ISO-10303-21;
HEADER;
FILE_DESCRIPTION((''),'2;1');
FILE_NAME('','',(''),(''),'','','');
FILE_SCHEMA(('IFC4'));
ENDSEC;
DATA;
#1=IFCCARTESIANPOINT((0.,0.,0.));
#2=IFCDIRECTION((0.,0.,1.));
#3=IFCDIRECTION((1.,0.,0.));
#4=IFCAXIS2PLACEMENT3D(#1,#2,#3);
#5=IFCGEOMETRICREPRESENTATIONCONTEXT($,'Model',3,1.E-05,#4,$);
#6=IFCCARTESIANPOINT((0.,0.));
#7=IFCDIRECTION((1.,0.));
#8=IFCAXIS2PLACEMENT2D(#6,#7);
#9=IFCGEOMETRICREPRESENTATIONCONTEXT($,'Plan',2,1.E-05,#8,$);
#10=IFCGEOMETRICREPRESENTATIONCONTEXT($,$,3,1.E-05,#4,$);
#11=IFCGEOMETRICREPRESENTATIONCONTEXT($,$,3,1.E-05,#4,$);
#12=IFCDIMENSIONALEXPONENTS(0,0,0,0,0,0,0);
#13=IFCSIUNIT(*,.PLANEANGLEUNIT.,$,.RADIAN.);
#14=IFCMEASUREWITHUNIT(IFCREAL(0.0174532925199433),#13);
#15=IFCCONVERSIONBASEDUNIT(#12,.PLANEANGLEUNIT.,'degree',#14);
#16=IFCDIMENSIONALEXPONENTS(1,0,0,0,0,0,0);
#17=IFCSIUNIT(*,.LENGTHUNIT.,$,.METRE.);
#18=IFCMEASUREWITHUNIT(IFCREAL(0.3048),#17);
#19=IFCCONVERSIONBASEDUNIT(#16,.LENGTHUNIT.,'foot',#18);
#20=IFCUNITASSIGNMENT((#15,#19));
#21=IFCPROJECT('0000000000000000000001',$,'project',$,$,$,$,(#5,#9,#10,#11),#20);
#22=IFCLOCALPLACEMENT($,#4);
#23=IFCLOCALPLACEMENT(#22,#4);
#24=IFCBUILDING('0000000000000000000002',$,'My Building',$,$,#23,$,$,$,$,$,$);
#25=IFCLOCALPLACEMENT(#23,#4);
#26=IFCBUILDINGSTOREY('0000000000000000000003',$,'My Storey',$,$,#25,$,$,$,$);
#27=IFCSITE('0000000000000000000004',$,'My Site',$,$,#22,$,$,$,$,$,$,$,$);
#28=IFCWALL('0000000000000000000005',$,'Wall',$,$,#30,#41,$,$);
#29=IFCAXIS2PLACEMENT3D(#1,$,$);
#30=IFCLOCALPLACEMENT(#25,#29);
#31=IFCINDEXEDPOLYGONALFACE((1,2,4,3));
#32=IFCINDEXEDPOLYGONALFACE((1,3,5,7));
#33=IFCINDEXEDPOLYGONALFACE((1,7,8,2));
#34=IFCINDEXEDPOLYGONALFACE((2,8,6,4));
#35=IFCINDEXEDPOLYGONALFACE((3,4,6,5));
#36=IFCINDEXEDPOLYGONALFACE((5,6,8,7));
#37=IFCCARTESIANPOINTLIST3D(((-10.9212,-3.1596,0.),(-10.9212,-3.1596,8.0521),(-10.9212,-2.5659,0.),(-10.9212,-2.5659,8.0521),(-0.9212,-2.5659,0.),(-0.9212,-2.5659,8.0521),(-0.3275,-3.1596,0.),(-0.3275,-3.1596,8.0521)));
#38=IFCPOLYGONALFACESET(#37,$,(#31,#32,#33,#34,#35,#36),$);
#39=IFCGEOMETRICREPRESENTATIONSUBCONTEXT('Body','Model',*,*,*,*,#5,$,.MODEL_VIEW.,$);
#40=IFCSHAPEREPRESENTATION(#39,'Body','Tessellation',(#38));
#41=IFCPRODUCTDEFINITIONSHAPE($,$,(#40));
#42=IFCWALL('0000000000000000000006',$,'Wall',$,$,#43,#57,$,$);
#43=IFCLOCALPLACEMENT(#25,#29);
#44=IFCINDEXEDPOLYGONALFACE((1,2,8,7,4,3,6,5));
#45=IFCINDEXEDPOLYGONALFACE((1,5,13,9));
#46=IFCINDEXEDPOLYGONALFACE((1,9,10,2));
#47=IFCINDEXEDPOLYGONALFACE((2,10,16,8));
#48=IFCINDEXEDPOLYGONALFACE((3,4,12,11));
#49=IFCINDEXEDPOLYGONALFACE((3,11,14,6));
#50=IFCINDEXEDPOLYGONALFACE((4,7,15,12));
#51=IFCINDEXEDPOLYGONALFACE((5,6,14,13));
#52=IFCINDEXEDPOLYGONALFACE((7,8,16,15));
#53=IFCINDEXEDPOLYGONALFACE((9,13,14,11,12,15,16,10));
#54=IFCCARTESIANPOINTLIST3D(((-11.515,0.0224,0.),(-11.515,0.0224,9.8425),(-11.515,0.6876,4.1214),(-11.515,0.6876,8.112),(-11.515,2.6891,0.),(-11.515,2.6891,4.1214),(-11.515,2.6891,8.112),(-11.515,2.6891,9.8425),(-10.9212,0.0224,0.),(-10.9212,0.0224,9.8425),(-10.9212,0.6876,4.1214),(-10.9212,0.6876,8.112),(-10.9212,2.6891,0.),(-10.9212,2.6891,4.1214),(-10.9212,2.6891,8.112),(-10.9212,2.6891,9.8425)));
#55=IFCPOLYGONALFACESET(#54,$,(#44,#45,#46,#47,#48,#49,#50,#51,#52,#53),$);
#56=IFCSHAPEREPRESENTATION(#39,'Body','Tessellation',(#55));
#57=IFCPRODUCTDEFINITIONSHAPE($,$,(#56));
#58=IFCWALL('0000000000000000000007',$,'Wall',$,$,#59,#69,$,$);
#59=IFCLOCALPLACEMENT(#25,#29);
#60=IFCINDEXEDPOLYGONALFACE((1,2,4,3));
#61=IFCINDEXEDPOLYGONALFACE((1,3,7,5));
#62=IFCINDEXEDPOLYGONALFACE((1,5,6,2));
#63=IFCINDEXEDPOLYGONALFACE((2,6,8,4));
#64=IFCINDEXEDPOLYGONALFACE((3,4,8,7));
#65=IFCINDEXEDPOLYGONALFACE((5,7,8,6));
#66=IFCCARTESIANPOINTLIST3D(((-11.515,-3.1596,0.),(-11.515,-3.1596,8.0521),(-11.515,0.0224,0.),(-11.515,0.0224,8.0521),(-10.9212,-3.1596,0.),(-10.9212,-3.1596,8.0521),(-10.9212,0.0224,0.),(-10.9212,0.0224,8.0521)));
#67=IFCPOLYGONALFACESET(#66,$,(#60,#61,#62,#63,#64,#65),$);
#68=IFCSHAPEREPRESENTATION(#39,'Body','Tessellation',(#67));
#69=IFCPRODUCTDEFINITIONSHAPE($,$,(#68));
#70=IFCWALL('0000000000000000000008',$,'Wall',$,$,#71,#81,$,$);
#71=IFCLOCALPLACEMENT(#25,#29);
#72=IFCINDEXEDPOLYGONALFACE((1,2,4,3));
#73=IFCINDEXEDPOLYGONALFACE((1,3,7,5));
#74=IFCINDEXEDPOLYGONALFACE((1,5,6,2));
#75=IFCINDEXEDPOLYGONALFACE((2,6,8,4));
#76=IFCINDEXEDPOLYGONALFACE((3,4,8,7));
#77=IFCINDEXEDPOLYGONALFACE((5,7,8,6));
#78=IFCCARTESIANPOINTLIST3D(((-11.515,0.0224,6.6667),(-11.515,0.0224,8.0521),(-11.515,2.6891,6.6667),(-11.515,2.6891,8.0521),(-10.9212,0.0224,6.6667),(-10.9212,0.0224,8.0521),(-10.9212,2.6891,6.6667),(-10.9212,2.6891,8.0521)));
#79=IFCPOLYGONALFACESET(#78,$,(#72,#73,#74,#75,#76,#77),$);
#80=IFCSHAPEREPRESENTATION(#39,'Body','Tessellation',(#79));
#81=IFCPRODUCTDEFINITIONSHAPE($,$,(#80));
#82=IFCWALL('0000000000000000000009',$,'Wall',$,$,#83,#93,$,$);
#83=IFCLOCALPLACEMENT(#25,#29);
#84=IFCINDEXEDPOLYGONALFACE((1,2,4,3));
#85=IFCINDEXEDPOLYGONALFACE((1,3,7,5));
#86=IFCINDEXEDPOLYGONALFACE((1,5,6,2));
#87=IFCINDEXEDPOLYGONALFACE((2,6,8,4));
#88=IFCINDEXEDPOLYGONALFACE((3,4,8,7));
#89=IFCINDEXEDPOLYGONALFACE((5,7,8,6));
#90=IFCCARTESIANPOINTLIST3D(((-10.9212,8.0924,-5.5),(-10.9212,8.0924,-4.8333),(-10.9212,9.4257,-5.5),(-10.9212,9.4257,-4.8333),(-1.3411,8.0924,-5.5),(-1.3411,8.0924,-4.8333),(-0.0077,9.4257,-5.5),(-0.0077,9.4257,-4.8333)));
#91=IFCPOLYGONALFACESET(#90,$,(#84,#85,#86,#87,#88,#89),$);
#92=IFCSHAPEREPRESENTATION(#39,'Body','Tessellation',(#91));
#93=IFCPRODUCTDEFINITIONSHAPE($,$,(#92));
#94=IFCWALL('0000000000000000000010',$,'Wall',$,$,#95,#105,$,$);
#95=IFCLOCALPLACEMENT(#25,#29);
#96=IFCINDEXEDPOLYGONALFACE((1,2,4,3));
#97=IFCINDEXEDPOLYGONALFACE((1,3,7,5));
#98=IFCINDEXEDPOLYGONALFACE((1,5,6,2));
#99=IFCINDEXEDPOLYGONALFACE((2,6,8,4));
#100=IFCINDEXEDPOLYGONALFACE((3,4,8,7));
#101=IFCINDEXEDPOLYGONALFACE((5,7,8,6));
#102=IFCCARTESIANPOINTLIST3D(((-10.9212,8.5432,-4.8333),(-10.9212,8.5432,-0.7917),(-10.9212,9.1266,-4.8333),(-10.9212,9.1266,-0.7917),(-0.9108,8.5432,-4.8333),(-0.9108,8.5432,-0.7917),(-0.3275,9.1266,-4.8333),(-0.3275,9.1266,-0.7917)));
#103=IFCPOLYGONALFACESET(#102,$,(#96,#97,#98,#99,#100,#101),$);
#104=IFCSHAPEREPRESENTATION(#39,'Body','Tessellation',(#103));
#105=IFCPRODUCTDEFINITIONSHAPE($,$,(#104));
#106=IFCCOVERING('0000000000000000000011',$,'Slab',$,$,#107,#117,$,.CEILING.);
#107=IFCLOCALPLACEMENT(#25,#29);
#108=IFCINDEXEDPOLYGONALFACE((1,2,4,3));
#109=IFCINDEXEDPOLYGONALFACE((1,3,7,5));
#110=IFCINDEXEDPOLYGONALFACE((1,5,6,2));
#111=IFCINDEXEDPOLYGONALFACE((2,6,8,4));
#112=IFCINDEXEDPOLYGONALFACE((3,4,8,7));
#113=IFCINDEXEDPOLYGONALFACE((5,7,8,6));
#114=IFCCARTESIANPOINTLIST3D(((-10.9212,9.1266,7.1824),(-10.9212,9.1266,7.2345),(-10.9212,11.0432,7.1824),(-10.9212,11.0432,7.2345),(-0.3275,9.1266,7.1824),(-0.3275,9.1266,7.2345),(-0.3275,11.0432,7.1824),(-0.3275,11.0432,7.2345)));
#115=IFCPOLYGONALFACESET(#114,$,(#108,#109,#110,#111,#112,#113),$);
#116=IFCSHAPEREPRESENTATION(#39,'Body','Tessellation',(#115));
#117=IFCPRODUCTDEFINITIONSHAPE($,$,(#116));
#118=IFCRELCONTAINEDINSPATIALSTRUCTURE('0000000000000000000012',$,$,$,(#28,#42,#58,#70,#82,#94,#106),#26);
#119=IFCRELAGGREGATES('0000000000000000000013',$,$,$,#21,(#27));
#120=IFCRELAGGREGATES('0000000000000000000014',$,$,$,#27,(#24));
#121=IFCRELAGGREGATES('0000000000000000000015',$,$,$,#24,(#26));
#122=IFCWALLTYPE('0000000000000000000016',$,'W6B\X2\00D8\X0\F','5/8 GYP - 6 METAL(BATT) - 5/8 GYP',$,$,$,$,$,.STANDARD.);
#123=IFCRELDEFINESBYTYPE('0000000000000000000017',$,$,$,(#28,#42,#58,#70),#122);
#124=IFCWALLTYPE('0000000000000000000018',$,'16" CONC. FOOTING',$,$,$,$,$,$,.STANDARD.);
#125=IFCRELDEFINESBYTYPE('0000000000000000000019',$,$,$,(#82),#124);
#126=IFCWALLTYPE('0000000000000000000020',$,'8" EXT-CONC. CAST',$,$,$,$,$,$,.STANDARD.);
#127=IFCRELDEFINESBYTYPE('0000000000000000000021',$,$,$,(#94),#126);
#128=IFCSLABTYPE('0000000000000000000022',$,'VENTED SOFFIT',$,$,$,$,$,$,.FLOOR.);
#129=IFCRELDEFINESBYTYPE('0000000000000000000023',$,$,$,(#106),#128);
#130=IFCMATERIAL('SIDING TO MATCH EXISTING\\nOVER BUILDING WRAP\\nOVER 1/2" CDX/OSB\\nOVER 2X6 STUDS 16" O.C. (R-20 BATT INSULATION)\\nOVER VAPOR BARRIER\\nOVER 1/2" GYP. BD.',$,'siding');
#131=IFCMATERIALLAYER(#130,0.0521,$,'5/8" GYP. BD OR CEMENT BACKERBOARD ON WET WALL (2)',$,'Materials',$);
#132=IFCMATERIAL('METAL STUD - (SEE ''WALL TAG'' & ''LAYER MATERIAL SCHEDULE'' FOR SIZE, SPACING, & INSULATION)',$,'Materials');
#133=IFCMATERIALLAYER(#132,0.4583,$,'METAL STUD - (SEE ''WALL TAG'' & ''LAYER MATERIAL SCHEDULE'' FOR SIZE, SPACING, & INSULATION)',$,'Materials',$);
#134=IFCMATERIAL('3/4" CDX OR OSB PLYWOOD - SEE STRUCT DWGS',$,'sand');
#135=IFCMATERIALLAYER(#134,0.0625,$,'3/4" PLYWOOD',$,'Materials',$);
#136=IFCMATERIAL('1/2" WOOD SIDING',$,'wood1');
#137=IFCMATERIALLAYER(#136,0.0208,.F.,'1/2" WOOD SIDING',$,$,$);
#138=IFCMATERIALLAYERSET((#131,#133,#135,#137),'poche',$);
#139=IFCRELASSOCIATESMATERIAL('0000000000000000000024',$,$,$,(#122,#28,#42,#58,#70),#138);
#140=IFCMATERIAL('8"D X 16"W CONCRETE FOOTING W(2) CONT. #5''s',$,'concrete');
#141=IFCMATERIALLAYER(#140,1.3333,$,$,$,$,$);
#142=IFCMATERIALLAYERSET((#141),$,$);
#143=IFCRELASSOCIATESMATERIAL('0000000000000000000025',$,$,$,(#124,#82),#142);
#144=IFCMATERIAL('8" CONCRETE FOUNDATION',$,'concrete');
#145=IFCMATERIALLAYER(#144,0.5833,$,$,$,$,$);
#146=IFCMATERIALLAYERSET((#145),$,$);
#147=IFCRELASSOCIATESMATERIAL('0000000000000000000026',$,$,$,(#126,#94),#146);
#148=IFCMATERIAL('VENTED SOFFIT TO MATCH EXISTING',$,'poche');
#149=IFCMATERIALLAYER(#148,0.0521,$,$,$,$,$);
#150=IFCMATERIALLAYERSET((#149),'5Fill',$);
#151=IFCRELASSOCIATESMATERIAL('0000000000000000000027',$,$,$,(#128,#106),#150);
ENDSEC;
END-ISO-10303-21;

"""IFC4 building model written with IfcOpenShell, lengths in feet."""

from ifc_helpers import new_model, entity, si_unit, converted_unit, frame, origin_with_axes, origin_2d_with_axis, place, context, subcontext, project, spatial, line, indexed_curve, outline, extrude, clip, halfspace, source, transform, mapped, material, layer, layer_set, layer_usage, type_object, element, save


model = new_model("IFC4")

# Units and contexts
model_context = context("Model", 3, precision=1e-05, world=origin_with_axes())
plan_context = context("Plan", 2, precision=1e-05, world=origin_2d_with_axis())
context_of_model_1 = context(None, 3, precision=1e-05, world=origin_with_axes())
context_of_model_2 = context(None, 3, precision=1e-05, world=origin_with_axes())
body_context = subcontext(model_context, "Body", "Model", "MODEL_VIEW")
ifc_project = project(units=[converted_unit("PLANEANGLEUNIT", "degree", entity("IfcReal", 0.0174532925199433), si_unit("PLANEANGLEUNIT", "RADIAN"), dimensions=[0, 0, 0, 0, 0, 0, 0]), converted_unit("LENGTHUNIT", "foot", entity("IfcReal", 0.3048), si_unit("LENGTHUNIT", "METRE"), dimensions=[1, 0, 0, 0, 0, 0, 0])], contexts=[model_context, plan_context, context_of_model_1, context_of_model_2])

# Site, building, storey
site_placement = place(None, origin_with_axes())
site = spatial("IfcSite", under=ifc_project, at=site_placement, Name="My Site")
building_placement = place(site_placement, origin_with_axes())
building = spatial("IfcBuilding", under=site, at=building_placement, Name="My Building")
storey_placement = place(building_placement, origin_with_axes())
storey = spatial("IfcBuildingStorey", under=building, at=storey_placement, Name="My Storey")

# Shared definitions
ifc_material_1 = material(Name="SIDING TO MATCH EXISTING\\nOVER BUILDING WRAP\\nOVER 1/2\" CDX/OSB\\nOVER 2X6 STUDS 16\" O.C. (R-20 BATT INSULATION)\\nOVER VAPOR BARRIER\\nOVER 1/2\" GYP. BD.", Category="siding")
ifc_layer_1 = layer(ifc_material_1, 0.0521, Name="5/8\" GYP. BD OR CEMENT BACKERBOARD ON WET WALL (2)", Category="Materials")
ifc_material_2 = material(Name="METAL STUD - (SEE 'WALL TAG' & 'LAYER MATERIAL SCHEDULE' FOR SIZE, SPACING, & INSULATION)", Category="Materials")
ifc_layer_2 = layer(ifc_material_2, 0.4583, Name="METAL STUD - (SEE 'WALL TAG' & 'LAYER MATERIAL SCHEDULE' FOR SIZE, SPACING, & INSULATION)", Category="Materials")
ifc_material_3 = material(Name="3/4\" CDX OR OSB PLYWOOD - SEE STRUCT DWGS", Category="sand")
ifc_layer_3 = layer(ifc_material_3, 0.0625, Name="3/4\" PLYWOOD", Category="Materials")
ifc_material_4 = material(Name="1/2\" WOOD SIDING", Category="wood1")
ifc_layer_4 = layer(ifc_material_4, 0.0208, ventilated=False, Name="1/2\" WOOD SIDING")
ifc_layer_set_1 = layer_set([ifc_layer_1, ifc_layer_2, ifc_layer_3, ifc_layer_4], Name="poche")
wall_type_1 = type_object("IfcWallType", Name="W6BØF", Description="5/8 GYP - 6 METAL(BATT) - 5/8 GYP", PredefinedType="STANDARD", material=ifc_layer_set_1)

# Wall
ifc_layer_usage_1 = layer_usage(ifc_layer_set_1, "AXIS2", "POSITIVE", 0.0)
wall_1_placement = place(storey_placement, frame((-0.3275, -2.5659, 0.0), z_axis=(0.0, 0.0, 1.0), x_axis=(-1.0, 0.0, 0.0)))
element("IfcWall", 1, at=wall_1_placement, inside=storey, type_object=wall_type_1, material=ifc_layer_usage_1, Name="Wall", context=body_context, shape_type="Clipping", body=[
    clip(extrude(outline(indexed_curve([(0.0, 0.0), (0.0, 0.5937), (10.5938, 0.5937), (10.5938, 0.0), (0.0, 0.0)], self_intersect=False)), origin_with_axes(), (0.0, 0.0, 1.0), 8.0521), halfspace(frame((0.5937, 0.0, 0.0), z_axis=(-0.707107, -0.707107, 0.0), x_axis=(-0.707107, 0.707107, 0.0)), False)),
])

# Wall, opening
ifc_layer_usage_2 = layer_usage(ifc_layer_set_1, "AXIS2", "POSITIVE", 0.0)
wall_2_placement = place(storey_placement, frame((-11.515, 2.6891, 0.0), z_axis=(0.0, 0.0, 1.0), x_axis=(0.0, -1.0, 0.0)))
wall_2 = element("IfcWall", 2, at=wall_2_placement, inside=storey, type_object=wall_type_1, material=ifc_layer_usage_2, Name="Wall", context=body_context, shape_type="SweptSolid", body=[
    extrude(outline(indexed_curve([(0.0, 0.0), (0.0, 0.5937), (2.6667, 0.5937), (2.6667, 0.0), (0.0, 0.0)], self_intersect=False)), origin_with_axes(), (0.0, 0.0, 1.0), 9.8425),
])
shared_shape_1 = source(origin_with_axes(), body_context, "Body", "SweptSolid", [
    extrude(outline(indexed_curve([(0.0, 0.0), (2.0015, 0.0), (2.0015, 3.9906), (0.0, 3.9906)], segments=[line(3, 2), line(2, 1), line(1, 4), line(4, 3)], self_intersect=False)), frame((0.0, -1.9685, 0.0), z_axis=(0.0, -1.0, 0.0), x_axis=(1.0, 0.0, 0.0)), (0.0, 0.0, -1.0), 3.937),
])
opening_1_placement = place(wall_2_placement, frame((0.0, 0.2038, 4.1214), z_axis=(0.0, 0.0, 1.0), x_axis=(1.0, 0.0, 0.0)))
element("IfcOpeningElement", 3, at=opening_1_placement, cuts=wall_2, PredefinedType="OPENING", context=body_context, shape_type="MappedRepresentation", body=[
    mapped(shared_shape_1, transform((0.0, 0.0, 0.0), x_axis=(1.0, 0.0, 0.0), y_axis=(0.0, 1.0, 0.0), z_axis=(0.0, 0.0, 1.0), scale=1.0)),
])

# Walls
ifc_layer_usage_3 = layer_usage(ifc_layer_set_1, "AXIS2", "POSITIVE", 0.0)
wall_3_placement = place(storey_placement, frame((-11.515, 0.0224, 0.0), z_axis=(0.0, 0.0, 1.0), x_axis=(0.0, -1.0, 0.0)))
element("IfcWall", 4, at=wall_3_placement, inside=storey, type_object=wall_type_1, material=ifc_layer_usage_3, Name="Wall", context=body_context, shape_type="SweptSolid", body=[
    extrude(outline(indexed_curve([(0.0, 0.0), (0.0, 0.5937), (3.182, 0.5937), (3.182, 0.0), (0.0, 0.0)], self_intersect=False)), origin_with_axes(), (0.0, 0.0, 1.0), 8.0521),
])
ifc_layer_usage_4 = layer_usage(ifc_layer_set_1, "AXIS2", "POSITIVE", 0.0)
wall_4_placement = place(storey_placement, frame((-11.515, 2.6891, 6.6667), z_axis=(0.0, 0.0, 1.0), x_axis=(0.0, -1.0, 0.0)))
element("IfcWall", 5, at=wall_4_placement, inside=storey, type_object=wall_type_1, material=ifc_layer_usage_4, Name="Wall", context=body_context, shape_type="SweptSolid", body=[
    extrude(outline(indexed_curve([(0.0, 0.0), (0.0, 0.5937), (2.6667, 0.5937), (2.6667, 0.0), (0.0, 0.0)], self_intersect=False)), origin_with_axes(), (0.0, 0.0, 1.0), 1.3854),
])
ifc_material_5 = material(Name="8\"D X 16\"W CONCRETE FOOTING W(2) CONT. #5's", Category="concrete")
ifc_layer_5 = layer(ifc_material_5, 1.3333)
ifc_layer_set_2 = layer_set([ifc_layer_5])
ifc_layer_usage_5 = layer_usage(ifc_layer_set_2, "AXIS2", "POSITIVE", 0.0)
wall_type_2 = type_object("IfcWallType", Name="16\" CONC. FOOTING", PredefinedType="STANDARD", material=ifc_layer_set_2)
wall_5_placement = place(storey_placement, frame((-0.0077, 9.4257, -5.5), z_axis=(0.0, 0.0, 1.0), x_axis=(-1.0, 0.0, 0.0)))
element("IfcWall", 6, at=wall_5_placement, inside=storey, type_object=wall_type_2, material=ifc_layer_usage_5, Name="Wall", context=body_context, shape_type="Clipping", body=[
    clip(extrude(outline(indexed_curve([(0.0, 0.0), (0.0, 1.3333), (10.9135, 1.3333), (10.9135, 0.0), (0.0, 0.0)], self_intersect=False)), origin_with_axes(), (0.0, 0.0, 1.0), 0.6667), halfspace(frame((0.0, 0.0, 5.5), z_axis=(-0.707107, 0.707107, 0.0), x_axis=(0.707107, 0.707107, 0.0)), False)),
])
ifc_material_6 = material(Name="8\" CONCRETE FOUNDATION", Category="concrete")
ifc_layer_6 = layer(ifc_material_6, 0.5833)
ifc_layer_set_3 = layer_set([ifc_layer_6])
ifc_layer_usage_6 = layer_usage(ifc_layer_set_3, "AXIS2", "POSITIVE", 0.0)
wall_type_3 = type_object("IfcWallType", Name="8\" EXT-CONC. CAST", PredefinedType="STANDARD", material=ifc_layer_set_3)
wall_6_placement = place(storey_placement, frame((-0.3275, 9.1266, -4.8333), z_axis=(0.0, 0.0, 1.0), x_axis=(-1.0, 0.0, 0.0)))
element("IfcWall", 7, at=wall_6_placement, inside=storey, type_object=wall_type_3, material=ifc_layer_usage_6, Name="Wall", context=body_context, shape_type="Clipping", body=[
    clip(extrude(outline(indexed_curve([(0.0, 0.0), (0.0, 0.5833), (10.5937, 0.5833), (10.5937, 0.0), (0.0, 0.0)], self_intersect=False)), origin_with_axes(), (0.0, 0.0, 1.0), 4.0417), halfspace(frame((0.0, 0.0, 4.8333), z_axis=(-0.707107, 0.707107, 0.0), x_axis=(0.707107, 0.707107, 0.0)), False)),
])

# Covering
ifc_material_7 = material(Name="VENTED SOFFIT TO MATCH EXISTING", Category="poche")
ifc_layer_7 = layer(ifc_material_7, 0.0521)
ifc_layer_set_4 = layer_set([ifc_layer_7], Name="5Fill")
ifc_layer_usage_7 = layer_usage(ifc_layer_set_4, "AXIS3", "POSITIVE", 0.0)
slab_type_1 = type_object("IfcSlabType", Name="VENTED SOFFIT", PredefinedType="FLOOR", material=ifc_layer_set_4)
covering_placement = place(storey_placement, frame((-10.9212, 9.1266, 7.1824), z_axis=(0.0, 0.0, 1.0), x_axis=(1.0, 0.0, 0.0)))
element("IfcCovering", 8, at=covering_placement, inside=storey, type_object=slab_type_1, material=ifc_layer_usage_7, Name="Slab", PredefinedType="CEILING", context=body_context, shape_type="SweptSolid", body=[
    extrude(outline(indexed_curve([(10.5938, 1.9167), (0.0, 1.9167), (0.0, 0.0), (10.5938, 0.0)], segments=[line(4, 1), line(1, 2), line(2, 3), line(3, 4)], self_intersect=False)), None, (0.0, 0.0, 1.0), 0.0521),
])

save(model, "model.ifc")
